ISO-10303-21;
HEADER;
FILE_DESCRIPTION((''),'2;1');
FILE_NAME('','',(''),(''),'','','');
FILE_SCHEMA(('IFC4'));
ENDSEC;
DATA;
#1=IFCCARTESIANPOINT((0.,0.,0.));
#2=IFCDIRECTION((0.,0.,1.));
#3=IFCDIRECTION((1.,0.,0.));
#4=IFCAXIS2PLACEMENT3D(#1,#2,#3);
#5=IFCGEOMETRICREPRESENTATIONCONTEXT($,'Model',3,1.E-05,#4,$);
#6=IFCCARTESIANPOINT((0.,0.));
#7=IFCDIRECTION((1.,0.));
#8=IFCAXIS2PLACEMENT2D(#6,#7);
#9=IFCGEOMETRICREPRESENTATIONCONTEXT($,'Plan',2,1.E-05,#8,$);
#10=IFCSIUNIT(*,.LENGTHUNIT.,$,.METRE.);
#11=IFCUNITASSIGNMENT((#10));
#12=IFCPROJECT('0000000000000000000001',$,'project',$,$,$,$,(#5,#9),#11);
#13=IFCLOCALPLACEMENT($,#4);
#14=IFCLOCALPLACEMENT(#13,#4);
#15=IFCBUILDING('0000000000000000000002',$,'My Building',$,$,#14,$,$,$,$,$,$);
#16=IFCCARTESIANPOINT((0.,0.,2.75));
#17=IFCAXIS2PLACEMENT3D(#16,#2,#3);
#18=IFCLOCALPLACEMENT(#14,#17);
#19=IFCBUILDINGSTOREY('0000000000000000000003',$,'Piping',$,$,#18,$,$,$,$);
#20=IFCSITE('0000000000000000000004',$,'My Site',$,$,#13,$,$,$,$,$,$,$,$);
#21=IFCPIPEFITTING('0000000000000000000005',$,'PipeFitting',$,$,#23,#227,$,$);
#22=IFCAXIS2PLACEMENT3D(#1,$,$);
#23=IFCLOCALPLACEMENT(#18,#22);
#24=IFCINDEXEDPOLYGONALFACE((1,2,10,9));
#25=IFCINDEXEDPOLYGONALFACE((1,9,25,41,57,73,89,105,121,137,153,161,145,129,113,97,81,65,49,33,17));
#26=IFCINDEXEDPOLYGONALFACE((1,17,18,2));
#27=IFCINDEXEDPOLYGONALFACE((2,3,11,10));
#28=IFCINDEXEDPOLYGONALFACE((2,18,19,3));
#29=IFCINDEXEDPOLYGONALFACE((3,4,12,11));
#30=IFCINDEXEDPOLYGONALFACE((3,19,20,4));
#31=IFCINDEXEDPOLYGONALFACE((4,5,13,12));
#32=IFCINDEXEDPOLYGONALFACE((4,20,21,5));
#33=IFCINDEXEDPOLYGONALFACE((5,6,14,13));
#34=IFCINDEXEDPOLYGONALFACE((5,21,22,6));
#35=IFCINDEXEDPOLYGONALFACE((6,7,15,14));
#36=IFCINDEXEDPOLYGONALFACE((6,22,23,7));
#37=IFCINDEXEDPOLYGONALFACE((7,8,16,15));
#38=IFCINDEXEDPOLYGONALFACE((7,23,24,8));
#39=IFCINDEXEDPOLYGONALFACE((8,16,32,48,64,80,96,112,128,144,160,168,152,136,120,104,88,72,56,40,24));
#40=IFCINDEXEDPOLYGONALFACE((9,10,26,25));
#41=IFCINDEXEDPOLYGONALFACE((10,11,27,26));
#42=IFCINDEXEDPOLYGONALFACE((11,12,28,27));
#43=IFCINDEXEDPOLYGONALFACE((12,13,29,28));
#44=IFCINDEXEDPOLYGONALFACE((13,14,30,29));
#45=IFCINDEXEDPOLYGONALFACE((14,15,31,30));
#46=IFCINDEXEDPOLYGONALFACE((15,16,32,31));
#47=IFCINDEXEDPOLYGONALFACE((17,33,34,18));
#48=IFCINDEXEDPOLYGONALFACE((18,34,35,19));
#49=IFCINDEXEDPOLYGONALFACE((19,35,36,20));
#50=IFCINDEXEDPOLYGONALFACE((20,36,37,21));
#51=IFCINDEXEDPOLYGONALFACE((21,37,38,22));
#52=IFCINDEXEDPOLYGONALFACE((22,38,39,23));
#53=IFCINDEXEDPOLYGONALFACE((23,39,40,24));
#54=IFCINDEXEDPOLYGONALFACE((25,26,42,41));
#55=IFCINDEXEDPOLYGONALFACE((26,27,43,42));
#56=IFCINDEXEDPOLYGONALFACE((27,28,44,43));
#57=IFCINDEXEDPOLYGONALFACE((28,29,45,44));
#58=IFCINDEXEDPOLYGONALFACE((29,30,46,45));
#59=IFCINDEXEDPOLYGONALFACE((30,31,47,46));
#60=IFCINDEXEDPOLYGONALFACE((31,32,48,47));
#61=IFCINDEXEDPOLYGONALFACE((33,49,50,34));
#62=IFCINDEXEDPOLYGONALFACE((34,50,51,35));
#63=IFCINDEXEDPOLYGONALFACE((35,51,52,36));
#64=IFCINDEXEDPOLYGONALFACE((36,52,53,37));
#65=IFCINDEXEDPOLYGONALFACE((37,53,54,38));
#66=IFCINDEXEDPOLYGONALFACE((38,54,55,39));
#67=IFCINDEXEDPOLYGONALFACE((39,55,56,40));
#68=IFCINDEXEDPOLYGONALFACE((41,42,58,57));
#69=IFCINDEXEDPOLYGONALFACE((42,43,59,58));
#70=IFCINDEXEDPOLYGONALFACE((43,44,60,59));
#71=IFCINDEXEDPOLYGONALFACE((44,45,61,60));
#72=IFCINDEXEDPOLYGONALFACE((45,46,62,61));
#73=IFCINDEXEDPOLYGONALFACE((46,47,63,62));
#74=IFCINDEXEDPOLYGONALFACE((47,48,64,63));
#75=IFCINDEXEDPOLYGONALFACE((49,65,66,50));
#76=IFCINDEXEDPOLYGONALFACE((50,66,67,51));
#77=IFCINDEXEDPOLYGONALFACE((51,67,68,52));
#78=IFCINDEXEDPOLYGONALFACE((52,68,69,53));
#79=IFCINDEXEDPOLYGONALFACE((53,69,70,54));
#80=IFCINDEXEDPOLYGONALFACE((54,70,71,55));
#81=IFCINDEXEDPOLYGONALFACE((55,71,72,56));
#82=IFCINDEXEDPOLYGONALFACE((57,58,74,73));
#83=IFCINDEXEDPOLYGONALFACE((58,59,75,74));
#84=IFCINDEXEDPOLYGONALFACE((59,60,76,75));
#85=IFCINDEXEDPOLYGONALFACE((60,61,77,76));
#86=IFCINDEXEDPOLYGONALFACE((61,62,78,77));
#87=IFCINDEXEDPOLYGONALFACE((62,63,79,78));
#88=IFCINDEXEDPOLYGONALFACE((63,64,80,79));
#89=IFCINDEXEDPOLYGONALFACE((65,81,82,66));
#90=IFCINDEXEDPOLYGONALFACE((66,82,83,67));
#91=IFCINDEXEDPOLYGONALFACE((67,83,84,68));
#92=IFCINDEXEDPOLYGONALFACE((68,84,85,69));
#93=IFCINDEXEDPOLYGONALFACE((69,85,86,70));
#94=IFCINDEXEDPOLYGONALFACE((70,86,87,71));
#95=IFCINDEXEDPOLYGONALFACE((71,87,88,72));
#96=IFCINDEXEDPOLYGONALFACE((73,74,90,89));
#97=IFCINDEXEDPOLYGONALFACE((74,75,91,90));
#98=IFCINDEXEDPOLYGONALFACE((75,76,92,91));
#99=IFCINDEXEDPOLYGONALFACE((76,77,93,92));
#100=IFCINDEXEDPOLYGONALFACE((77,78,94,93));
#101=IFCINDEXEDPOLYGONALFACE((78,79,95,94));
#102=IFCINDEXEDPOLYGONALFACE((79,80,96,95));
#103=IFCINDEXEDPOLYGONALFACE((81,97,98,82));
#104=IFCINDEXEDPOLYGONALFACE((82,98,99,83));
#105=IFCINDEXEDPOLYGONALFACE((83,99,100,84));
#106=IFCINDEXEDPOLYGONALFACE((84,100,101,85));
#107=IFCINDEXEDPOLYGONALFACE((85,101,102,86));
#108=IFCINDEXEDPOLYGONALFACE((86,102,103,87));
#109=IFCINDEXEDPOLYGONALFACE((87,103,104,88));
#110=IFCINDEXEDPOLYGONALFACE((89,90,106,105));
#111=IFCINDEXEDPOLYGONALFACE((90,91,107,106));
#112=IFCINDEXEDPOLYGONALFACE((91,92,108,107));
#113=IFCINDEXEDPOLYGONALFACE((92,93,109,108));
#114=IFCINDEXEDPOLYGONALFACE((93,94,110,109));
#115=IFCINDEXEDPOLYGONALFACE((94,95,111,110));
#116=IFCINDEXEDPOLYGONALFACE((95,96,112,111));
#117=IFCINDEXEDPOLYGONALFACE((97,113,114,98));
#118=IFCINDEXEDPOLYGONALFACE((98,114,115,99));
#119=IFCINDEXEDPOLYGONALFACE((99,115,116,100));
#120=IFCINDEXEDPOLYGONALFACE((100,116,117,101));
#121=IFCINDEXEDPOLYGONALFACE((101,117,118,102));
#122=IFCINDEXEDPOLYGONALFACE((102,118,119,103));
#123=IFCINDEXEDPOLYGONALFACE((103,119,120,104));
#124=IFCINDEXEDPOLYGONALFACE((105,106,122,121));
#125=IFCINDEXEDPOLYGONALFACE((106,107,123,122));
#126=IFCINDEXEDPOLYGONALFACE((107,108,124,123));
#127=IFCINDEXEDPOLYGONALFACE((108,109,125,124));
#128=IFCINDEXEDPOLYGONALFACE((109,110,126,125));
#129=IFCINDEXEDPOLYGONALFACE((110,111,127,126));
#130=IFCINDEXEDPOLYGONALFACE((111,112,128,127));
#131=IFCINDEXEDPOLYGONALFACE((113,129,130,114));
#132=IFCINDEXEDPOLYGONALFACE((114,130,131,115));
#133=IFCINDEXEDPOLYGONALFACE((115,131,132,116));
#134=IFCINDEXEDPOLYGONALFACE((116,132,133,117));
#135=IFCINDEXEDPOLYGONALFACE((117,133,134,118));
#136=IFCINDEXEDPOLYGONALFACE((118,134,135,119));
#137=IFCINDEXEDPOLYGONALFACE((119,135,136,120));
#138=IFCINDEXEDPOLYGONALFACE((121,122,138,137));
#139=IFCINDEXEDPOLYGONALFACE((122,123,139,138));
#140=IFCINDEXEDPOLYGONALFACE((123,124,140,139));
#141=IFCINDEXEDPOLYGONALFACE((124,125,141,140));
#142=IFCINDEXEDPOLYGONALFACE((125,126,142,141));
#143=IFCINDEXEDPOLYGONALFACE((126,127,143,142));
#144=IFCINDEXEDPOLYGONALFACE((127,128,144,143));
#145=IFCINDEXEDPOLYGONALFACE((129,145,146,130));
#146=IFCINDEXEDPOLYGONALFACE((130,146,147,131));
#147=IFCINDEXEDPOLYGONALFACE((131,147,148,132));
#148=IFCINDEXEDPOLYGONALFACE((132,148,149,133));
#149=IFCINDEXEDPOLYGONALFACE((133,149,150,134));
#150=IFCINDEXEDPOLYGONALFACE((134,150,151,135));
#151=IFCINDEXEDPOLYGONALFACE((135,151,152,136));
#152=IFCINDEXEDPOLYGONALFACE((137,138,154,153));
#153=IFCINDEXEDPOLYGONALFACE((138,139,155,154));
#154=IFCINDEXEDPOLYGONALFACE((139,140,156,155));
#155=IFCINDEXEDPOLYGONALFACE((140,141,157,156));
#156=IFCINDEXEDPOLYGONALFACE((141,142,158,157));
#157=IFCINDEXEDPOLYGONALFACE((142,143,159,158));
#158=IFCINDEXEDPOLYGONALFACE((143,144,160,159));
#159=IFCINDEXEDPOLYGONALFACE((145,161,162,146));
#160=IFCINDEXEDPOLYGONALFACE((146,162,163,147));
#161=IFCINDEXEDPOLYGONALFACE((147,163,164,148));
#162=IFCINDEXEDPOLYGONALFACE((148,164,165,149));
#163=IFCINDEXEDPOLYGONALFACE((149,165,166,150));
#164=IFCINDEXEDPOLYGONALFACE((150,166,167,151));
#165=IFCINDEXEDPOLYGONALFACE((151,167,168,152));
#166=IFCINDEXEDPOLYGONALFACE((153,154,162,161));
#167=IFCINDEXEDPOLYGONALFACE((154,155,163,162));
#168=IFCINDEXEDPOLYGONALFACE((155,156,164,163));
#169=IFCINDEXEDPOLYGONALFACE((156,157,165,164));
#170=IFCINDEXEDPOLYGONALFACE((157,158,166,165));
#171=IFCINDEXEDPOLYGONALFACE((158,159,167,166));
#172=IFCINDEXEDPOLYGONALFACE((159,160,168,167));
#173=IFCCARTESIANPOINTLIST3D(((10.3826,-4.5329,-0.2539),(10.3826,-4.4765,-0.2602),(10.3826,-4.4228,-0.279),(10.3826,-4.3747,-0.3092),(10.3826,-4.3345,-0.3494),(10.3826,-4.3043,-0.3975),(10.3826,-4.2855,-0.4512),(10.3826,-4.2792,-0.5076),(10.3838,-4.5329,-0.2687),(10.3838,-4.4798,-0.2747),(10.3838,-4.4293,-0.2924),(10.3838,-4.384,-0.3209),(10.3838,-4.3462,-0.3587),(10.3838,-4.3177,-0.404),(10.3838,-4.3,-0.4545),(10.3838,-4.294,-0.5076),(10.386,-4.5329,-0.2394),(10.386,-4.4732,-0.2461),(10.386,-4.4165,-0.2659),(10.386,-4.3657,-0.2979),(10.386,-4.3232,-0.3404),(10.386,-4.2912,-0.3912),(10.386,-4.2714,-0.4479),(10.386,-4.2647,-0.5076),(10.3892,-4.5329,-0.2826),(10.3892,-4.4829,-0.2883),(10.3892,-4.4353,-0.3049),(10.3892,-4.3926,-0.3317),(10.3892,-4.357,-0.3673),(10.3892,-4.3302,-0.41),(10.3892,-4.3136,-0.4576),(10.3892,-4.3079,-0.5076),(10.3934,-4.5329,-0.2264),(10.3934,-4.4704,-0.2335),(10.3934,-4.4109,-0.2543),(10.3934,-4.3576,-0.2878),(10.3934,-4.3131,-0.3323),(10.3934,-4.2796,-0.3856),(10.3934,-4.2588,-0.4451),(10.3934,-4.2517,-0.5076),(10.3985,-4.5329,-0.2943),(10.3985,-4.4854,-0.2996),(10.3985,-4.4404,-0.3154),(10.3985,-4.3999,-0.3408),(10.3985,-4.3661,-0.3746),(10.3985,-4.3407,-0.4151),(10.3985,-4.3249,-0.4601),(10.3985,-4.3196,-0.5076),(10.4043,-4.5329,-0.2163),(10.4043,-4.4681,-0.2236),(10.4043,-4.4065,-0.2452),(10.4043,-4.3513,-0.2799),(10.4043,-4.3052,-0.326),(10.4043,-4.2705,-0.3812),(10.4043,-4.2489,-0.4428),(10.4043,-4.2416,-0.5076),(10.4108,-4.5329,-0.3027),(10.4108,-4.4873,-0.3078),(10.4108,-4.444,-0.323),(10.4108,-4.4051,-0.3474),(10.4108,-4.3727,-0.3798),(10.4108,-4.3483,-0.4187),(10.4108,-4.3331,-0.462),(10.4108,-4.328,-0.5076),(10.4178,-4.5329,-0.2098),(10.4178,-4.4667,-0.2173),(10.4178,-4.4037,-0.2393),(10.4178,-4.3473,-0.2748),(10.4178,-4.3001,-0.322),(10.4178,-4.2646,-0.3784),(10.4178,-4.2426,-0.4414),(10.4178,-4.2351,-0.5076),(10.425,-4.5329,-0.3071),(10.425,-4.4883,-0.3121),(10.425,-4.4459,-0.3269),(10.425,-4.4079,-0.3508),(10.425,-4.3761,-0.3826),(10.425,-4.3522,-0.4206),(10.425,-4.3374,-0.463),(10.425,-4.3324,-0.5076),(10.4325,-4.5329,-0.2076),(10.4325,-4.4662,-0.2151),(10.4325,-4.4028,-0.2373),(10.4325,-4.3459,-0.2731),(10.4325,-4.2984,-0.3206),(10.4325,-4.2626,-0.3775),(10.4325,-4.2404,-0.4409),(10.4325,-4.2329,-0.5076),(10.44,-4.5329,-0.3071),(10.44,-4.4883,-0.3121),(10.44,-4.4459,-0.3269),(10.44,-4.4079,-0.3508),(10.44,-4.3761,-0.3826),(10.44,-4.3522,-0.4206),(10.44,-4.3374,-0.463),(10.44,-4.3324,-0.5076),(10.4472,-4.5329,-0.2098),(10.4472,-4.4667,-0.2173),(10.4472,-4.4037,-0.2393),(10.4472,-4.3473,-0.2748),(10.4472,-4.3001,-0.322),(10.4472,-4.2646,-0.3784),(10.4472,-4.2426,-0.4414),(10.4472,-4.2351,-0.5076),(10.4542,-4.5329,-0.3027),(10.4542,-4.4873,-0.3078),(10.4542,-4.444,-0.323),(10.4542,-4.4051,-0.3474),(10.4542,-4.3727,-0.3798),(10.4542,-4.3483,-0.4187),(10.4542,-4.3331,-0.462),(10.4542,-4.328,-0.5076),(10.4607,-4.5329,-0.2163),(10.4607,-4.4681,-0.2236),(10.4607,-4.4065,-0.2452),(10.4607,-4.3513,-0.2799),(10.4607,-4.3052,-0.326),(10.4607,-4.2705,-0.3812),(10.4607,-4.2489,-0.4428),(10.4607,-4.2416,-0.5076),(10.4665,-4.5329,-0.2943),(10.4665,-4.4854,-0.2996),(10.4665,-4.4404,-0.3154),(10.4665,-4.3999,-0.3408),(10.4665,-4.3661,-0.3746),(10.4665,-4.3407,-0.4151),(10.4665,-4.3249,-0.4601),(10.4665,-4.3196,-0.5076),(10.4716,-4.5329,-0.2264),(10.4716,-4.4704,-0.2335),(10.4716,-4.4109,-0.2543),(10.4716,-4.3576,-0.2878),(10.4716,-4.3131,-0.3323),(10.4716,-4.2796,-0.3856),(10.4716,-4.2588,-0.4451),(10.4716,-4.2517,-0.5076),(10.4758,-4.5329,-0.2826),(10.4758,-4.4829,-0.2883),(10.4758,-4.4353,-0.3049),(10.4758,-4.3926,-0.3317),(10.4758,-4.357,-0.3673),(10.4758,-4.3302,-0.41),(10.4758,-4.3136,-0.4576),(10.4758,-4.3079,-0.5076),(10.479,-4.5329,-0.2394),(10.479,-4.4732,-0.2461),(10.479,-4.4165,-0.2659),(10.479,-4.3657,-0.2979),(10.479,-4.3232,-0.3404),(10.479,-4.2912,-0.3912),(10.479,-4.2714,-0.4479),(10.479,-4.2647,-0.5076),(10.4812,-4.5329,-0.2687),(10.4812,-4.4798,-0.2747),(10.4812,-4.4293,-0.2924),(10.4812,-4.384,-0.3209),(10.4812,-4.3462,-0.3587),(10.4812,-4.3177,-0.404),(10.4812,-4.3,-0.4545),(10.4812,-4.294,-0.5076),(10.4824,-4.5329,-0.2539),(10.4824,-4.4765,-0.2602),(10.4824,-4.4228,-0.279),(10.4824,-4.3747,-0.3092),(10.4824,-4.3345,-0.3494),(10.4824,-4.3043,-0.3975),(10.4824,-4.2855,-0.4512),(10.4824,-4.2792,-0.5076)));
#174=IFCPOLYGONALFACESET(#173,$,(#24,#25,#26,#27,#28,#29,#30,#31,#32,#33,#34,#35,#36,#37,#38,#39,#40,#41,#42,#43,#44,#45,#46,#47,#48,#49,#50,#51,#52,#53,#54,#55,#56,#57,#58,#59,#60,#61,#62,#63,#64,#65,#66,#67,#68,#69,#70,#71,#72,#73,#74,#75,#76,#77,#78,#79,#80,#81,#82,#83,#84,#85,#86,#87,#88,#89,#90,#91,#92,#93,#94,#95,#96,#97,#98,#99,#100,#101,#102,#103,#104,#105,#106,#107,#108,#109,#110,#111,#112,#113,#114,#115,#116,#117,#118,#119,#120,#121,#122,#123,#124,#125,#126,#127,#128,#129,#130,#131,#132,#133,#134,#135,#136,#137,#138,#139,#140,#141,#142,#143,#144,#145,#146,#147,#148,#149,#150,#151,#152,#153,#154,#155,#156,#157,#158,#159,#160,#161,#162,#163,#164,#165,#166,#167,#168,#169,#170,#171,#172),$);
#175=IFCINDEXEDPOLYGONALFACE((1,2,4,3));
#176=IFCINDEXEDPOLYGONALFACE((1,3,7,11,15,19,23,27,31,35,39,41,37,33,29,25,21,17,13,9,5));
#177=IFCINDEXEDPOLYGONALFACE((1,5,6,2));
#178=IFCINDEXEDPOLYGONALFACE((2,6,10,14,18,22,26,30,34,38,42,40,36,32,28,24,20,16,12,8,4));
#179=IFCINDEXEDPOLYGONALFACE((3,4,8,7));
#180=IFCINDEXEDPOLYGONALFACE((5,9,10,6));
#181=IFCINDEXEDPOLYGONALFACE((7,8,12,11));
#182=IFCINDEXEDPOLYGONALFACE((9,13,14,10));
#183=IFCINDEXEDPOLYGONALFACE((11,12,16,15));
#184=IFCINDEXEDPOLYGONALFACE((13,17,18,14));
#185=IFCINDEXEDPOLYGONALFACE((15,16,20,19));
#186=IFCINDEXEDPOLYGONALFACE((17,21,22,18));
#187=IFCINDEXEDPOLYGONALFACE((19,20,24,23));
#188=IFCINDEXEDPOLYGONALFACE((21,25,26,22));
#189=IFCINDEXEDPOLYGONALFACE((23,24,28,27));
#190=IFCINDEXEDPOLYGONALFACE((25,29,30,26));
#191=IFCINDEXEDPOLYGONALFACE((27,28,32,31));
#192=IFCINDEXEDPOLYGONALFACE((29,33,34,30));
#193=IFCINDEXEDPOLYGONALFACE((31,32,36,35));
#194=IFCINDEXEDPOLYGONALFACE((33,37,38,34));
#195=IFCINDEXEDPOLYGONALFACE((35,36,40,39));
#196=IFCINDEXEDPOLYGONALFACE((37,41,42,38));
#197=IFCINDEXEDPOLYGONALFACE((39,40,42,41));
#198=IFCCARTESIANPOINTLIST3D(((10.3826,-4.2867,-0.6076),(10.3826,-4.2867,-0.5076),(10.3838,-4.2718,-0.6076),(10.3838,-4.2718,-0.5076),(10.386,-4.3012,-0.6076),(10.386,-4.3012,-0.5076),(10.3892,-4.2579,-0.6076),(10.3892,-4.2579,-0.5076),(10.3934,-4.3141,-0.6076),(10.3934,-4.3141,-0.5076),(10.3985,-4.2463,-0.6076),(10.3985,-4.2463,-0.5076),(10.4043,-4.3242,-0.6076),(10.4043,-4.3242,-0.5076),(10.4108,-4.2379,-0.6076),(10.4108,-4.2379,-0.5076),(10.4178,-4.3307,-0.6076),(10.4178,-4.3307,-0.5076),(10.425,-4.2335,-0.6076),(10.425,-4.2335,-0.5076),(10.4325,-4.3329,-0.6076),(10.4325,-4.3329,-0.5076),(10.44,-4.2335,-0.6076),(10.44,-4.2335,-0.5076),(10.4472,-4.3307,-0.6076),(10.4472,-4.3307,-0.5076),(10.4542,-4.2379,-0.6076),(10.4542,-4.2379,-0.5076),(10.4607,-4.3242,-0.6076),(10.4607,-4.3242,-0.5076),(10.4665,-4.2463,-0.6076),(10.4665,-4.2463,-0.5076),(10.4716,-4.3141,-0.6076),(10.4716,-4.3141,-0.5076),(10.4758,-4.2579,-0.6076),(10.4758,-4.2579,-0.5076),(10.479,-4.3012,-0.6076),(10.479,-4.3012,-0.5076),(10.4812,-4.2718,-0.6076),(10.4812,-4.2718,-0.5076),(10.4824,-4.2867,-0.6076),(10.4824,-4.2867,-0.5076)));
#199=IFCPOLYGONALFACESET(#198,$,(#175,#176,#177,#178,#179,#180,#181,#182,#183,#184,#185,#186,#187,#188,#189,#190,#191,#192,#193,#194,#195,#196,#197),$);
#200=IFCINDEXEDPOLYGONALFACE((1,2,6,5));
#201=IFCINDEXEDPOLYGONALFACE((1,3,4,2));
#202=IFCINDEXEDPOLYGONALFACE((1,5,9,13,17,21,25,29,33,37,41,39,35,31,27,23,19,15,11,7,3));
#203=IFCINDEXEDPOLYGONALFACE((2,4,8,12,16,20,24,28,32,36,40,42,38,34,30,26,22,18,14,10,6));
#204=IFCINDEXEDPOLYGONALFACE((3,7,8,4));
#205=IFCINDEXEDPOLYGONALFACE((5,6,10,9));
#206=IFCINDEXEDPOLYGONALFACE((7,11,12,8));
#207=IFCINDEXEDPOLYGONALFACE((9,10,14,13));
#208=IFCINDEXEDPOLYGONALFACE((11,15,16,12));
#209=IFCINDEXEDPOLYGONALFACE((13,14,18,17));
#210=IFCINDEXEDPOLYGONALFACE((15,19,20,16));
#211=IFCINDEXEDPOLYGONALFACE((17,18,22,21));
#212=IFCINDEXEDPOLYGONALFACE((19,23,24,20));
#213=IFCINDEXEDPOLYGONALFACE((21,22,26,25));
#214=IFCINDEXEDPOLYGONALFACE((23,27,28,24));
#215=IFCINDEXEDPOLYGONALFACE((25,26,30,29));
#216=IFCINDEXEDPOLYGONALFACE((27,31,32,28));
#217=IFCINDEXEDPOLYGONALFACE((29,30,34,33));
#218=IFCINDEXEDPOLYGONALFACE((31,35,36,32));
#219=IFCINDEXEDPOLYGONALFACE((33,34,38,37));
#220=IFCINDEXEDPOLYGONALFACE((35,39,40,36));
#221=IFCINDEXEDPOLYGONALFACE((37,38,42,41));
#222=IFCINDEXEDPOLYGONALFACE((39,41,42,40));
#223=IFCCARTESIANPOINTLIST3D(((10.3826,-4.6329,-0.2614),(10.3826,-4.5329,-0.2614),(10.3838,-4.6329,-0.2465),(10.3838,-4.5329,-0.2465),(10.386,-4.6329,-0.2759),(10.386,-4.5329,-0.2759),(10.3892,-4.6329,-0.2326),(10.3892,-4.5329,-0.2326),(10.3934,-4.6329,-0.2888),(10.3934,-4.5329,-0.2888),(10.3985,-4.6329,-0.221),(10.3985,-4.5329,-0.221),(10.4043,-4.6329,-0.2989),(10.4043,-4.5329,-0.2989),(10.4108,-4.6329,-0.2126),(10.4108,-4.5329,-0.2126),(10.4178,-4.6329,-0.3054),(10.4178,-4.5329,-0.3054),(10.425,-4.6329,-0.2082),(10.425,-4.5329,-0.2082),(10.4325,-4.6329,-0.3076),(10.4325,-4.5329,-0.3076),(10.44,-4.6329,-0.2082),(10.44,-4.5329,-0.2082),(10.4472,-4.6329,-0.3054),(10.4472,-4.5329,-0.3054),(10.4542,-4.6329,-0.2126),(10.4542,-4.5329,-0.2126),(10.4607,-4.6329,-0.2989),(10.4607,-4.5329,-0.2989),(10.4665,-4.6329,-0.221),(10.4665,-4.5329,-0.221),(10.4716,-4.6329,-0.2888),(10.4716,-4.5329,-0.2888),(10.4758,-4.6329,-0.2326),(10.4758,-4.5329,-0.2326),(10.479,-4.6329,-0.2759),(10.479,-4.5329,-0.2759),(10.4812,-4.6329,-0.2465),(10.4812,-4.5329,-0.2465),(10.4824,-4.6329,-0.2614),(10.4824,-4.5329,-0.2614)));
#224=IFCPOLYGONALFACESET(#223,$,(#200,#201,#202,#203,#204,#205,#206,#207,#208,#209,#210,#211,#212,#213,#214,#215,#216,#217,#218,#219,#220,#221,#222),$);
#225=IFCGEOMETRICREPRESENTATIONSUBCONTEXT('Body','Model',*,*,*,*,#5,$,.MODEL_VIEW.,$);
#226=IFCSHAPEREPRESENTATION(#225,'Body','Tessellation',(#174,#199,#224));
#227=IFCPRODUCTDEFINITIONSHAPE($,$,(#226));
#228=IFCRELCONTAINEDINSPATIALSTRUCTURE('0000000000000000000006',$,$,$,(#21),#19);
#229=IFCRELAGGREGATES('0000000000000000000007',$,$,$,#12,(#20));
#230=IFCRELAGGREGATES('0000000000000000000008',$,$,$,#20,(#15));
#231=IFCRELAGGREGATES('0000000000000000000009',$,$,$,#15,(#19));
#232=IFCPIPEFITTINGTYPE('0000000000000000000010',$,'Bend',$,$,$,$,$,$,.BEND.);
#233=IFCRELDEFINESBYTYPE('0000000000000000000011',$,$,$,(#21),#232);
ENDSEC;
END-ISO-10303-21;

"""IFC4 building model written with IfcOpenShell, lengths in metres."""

from ifc_helpers import new_model, entity, si_unit, frame, origin_with_axes, origin_2d_with_axis, place, context, subcontext, project, spatial, circle, extrude, source, transform, mapped, type_object, type_shapes, element, save


model = new_model("IFC4")

# Units and contexts
model_context = context("Model", 3, precision=1e-05, world=origin_with_axes())
plan_context = context("Plan", 2, precision=1e-05, world=origin_2d_with_axis())
body_context = subcontext(model_context, "Body", "Model", "MODEL_VIEW")
ifc_project = project(units=[si_unit("LENGTHUNIT", "METRE")], contexts=[model_context, plan_context])

# Site, building, storey
site_placement = place(None, origin_with_axes())
site = spatial("IfcSite", under=ifc_project, at=site_placement, Name="My Site")
building_placement = place(site_placement, origin_with_axes())
building = spatial("IfcBuilding", under=site, at=building_placement, Name="My Building")
storey_placement = place(building_placement, frame((0.0, 0.0, 2.75), z_axis=(0.0, 0.0, 1.0), x_axis=(1.0, 0.0, 0.0)))
storey = spatial("IfcBuildingStorey", under=building, at=storey_placement, Name="Piping")

# Pipe fitting
pipe_fitting_type = type_object("IfcPipeFittingType", Name="Bend", PredefinedType="BEND")
shared_shape = source(origin_with_axes(), body_context, "Body", "SolidModel", [
    entity("IfcSweptDiskSolid", entity("IfcIndexedPolyCurve", entity("IfcCartesianPointList3D", [[0.0, 0.0, -0.1], [0.0732, 0.0, -0.2768], [0.25, 0.0, -0.35]]), [entity("IfcArcIndex", [1, 2, 3])]), 0.05),
    extrude(circle(Radius=0.05), origin_with_axes(), (0.0, 0.0, -1.0), 0.1),
    extrude(circle(Radius=0.05), frame((0.25, 0.0, -0.35), z_axis=(1.0, 0.0, 0.0), x_axis=(0.0, 0.0, 1.0)), (0.0, 0.0, 1.0), 0.1),
])
type_shapes(pipe_fitting_type, [shared_shape])
for number, where, z_axis, x_axis, name in (
    (1, (10.4325, -4.2829, -0.6076), (0.0, 0.0, -1.0), (0.0, -1.0, 0.0), "PipeFitting"),
):
    element("IfcPipeFitting", number, at=place(storey_placement, frame(where, z_axis=z_axis, x_axis=x_axis)), inside=storey, type_object=pipe_fitting_type, Name=name, context=body_context, shape_type="MappedRepresentation", body=[
        mapped(shared_shape, transform((0.0, 0.0, 0.0), x_axis=(1.0, 0.0, 0.0), y_axis=(0.0, 1.0, 0.0), z_axis=(0.0, 0.0, 1.0), scale=1.0)),
    ])

save(model, "model.ifc")
